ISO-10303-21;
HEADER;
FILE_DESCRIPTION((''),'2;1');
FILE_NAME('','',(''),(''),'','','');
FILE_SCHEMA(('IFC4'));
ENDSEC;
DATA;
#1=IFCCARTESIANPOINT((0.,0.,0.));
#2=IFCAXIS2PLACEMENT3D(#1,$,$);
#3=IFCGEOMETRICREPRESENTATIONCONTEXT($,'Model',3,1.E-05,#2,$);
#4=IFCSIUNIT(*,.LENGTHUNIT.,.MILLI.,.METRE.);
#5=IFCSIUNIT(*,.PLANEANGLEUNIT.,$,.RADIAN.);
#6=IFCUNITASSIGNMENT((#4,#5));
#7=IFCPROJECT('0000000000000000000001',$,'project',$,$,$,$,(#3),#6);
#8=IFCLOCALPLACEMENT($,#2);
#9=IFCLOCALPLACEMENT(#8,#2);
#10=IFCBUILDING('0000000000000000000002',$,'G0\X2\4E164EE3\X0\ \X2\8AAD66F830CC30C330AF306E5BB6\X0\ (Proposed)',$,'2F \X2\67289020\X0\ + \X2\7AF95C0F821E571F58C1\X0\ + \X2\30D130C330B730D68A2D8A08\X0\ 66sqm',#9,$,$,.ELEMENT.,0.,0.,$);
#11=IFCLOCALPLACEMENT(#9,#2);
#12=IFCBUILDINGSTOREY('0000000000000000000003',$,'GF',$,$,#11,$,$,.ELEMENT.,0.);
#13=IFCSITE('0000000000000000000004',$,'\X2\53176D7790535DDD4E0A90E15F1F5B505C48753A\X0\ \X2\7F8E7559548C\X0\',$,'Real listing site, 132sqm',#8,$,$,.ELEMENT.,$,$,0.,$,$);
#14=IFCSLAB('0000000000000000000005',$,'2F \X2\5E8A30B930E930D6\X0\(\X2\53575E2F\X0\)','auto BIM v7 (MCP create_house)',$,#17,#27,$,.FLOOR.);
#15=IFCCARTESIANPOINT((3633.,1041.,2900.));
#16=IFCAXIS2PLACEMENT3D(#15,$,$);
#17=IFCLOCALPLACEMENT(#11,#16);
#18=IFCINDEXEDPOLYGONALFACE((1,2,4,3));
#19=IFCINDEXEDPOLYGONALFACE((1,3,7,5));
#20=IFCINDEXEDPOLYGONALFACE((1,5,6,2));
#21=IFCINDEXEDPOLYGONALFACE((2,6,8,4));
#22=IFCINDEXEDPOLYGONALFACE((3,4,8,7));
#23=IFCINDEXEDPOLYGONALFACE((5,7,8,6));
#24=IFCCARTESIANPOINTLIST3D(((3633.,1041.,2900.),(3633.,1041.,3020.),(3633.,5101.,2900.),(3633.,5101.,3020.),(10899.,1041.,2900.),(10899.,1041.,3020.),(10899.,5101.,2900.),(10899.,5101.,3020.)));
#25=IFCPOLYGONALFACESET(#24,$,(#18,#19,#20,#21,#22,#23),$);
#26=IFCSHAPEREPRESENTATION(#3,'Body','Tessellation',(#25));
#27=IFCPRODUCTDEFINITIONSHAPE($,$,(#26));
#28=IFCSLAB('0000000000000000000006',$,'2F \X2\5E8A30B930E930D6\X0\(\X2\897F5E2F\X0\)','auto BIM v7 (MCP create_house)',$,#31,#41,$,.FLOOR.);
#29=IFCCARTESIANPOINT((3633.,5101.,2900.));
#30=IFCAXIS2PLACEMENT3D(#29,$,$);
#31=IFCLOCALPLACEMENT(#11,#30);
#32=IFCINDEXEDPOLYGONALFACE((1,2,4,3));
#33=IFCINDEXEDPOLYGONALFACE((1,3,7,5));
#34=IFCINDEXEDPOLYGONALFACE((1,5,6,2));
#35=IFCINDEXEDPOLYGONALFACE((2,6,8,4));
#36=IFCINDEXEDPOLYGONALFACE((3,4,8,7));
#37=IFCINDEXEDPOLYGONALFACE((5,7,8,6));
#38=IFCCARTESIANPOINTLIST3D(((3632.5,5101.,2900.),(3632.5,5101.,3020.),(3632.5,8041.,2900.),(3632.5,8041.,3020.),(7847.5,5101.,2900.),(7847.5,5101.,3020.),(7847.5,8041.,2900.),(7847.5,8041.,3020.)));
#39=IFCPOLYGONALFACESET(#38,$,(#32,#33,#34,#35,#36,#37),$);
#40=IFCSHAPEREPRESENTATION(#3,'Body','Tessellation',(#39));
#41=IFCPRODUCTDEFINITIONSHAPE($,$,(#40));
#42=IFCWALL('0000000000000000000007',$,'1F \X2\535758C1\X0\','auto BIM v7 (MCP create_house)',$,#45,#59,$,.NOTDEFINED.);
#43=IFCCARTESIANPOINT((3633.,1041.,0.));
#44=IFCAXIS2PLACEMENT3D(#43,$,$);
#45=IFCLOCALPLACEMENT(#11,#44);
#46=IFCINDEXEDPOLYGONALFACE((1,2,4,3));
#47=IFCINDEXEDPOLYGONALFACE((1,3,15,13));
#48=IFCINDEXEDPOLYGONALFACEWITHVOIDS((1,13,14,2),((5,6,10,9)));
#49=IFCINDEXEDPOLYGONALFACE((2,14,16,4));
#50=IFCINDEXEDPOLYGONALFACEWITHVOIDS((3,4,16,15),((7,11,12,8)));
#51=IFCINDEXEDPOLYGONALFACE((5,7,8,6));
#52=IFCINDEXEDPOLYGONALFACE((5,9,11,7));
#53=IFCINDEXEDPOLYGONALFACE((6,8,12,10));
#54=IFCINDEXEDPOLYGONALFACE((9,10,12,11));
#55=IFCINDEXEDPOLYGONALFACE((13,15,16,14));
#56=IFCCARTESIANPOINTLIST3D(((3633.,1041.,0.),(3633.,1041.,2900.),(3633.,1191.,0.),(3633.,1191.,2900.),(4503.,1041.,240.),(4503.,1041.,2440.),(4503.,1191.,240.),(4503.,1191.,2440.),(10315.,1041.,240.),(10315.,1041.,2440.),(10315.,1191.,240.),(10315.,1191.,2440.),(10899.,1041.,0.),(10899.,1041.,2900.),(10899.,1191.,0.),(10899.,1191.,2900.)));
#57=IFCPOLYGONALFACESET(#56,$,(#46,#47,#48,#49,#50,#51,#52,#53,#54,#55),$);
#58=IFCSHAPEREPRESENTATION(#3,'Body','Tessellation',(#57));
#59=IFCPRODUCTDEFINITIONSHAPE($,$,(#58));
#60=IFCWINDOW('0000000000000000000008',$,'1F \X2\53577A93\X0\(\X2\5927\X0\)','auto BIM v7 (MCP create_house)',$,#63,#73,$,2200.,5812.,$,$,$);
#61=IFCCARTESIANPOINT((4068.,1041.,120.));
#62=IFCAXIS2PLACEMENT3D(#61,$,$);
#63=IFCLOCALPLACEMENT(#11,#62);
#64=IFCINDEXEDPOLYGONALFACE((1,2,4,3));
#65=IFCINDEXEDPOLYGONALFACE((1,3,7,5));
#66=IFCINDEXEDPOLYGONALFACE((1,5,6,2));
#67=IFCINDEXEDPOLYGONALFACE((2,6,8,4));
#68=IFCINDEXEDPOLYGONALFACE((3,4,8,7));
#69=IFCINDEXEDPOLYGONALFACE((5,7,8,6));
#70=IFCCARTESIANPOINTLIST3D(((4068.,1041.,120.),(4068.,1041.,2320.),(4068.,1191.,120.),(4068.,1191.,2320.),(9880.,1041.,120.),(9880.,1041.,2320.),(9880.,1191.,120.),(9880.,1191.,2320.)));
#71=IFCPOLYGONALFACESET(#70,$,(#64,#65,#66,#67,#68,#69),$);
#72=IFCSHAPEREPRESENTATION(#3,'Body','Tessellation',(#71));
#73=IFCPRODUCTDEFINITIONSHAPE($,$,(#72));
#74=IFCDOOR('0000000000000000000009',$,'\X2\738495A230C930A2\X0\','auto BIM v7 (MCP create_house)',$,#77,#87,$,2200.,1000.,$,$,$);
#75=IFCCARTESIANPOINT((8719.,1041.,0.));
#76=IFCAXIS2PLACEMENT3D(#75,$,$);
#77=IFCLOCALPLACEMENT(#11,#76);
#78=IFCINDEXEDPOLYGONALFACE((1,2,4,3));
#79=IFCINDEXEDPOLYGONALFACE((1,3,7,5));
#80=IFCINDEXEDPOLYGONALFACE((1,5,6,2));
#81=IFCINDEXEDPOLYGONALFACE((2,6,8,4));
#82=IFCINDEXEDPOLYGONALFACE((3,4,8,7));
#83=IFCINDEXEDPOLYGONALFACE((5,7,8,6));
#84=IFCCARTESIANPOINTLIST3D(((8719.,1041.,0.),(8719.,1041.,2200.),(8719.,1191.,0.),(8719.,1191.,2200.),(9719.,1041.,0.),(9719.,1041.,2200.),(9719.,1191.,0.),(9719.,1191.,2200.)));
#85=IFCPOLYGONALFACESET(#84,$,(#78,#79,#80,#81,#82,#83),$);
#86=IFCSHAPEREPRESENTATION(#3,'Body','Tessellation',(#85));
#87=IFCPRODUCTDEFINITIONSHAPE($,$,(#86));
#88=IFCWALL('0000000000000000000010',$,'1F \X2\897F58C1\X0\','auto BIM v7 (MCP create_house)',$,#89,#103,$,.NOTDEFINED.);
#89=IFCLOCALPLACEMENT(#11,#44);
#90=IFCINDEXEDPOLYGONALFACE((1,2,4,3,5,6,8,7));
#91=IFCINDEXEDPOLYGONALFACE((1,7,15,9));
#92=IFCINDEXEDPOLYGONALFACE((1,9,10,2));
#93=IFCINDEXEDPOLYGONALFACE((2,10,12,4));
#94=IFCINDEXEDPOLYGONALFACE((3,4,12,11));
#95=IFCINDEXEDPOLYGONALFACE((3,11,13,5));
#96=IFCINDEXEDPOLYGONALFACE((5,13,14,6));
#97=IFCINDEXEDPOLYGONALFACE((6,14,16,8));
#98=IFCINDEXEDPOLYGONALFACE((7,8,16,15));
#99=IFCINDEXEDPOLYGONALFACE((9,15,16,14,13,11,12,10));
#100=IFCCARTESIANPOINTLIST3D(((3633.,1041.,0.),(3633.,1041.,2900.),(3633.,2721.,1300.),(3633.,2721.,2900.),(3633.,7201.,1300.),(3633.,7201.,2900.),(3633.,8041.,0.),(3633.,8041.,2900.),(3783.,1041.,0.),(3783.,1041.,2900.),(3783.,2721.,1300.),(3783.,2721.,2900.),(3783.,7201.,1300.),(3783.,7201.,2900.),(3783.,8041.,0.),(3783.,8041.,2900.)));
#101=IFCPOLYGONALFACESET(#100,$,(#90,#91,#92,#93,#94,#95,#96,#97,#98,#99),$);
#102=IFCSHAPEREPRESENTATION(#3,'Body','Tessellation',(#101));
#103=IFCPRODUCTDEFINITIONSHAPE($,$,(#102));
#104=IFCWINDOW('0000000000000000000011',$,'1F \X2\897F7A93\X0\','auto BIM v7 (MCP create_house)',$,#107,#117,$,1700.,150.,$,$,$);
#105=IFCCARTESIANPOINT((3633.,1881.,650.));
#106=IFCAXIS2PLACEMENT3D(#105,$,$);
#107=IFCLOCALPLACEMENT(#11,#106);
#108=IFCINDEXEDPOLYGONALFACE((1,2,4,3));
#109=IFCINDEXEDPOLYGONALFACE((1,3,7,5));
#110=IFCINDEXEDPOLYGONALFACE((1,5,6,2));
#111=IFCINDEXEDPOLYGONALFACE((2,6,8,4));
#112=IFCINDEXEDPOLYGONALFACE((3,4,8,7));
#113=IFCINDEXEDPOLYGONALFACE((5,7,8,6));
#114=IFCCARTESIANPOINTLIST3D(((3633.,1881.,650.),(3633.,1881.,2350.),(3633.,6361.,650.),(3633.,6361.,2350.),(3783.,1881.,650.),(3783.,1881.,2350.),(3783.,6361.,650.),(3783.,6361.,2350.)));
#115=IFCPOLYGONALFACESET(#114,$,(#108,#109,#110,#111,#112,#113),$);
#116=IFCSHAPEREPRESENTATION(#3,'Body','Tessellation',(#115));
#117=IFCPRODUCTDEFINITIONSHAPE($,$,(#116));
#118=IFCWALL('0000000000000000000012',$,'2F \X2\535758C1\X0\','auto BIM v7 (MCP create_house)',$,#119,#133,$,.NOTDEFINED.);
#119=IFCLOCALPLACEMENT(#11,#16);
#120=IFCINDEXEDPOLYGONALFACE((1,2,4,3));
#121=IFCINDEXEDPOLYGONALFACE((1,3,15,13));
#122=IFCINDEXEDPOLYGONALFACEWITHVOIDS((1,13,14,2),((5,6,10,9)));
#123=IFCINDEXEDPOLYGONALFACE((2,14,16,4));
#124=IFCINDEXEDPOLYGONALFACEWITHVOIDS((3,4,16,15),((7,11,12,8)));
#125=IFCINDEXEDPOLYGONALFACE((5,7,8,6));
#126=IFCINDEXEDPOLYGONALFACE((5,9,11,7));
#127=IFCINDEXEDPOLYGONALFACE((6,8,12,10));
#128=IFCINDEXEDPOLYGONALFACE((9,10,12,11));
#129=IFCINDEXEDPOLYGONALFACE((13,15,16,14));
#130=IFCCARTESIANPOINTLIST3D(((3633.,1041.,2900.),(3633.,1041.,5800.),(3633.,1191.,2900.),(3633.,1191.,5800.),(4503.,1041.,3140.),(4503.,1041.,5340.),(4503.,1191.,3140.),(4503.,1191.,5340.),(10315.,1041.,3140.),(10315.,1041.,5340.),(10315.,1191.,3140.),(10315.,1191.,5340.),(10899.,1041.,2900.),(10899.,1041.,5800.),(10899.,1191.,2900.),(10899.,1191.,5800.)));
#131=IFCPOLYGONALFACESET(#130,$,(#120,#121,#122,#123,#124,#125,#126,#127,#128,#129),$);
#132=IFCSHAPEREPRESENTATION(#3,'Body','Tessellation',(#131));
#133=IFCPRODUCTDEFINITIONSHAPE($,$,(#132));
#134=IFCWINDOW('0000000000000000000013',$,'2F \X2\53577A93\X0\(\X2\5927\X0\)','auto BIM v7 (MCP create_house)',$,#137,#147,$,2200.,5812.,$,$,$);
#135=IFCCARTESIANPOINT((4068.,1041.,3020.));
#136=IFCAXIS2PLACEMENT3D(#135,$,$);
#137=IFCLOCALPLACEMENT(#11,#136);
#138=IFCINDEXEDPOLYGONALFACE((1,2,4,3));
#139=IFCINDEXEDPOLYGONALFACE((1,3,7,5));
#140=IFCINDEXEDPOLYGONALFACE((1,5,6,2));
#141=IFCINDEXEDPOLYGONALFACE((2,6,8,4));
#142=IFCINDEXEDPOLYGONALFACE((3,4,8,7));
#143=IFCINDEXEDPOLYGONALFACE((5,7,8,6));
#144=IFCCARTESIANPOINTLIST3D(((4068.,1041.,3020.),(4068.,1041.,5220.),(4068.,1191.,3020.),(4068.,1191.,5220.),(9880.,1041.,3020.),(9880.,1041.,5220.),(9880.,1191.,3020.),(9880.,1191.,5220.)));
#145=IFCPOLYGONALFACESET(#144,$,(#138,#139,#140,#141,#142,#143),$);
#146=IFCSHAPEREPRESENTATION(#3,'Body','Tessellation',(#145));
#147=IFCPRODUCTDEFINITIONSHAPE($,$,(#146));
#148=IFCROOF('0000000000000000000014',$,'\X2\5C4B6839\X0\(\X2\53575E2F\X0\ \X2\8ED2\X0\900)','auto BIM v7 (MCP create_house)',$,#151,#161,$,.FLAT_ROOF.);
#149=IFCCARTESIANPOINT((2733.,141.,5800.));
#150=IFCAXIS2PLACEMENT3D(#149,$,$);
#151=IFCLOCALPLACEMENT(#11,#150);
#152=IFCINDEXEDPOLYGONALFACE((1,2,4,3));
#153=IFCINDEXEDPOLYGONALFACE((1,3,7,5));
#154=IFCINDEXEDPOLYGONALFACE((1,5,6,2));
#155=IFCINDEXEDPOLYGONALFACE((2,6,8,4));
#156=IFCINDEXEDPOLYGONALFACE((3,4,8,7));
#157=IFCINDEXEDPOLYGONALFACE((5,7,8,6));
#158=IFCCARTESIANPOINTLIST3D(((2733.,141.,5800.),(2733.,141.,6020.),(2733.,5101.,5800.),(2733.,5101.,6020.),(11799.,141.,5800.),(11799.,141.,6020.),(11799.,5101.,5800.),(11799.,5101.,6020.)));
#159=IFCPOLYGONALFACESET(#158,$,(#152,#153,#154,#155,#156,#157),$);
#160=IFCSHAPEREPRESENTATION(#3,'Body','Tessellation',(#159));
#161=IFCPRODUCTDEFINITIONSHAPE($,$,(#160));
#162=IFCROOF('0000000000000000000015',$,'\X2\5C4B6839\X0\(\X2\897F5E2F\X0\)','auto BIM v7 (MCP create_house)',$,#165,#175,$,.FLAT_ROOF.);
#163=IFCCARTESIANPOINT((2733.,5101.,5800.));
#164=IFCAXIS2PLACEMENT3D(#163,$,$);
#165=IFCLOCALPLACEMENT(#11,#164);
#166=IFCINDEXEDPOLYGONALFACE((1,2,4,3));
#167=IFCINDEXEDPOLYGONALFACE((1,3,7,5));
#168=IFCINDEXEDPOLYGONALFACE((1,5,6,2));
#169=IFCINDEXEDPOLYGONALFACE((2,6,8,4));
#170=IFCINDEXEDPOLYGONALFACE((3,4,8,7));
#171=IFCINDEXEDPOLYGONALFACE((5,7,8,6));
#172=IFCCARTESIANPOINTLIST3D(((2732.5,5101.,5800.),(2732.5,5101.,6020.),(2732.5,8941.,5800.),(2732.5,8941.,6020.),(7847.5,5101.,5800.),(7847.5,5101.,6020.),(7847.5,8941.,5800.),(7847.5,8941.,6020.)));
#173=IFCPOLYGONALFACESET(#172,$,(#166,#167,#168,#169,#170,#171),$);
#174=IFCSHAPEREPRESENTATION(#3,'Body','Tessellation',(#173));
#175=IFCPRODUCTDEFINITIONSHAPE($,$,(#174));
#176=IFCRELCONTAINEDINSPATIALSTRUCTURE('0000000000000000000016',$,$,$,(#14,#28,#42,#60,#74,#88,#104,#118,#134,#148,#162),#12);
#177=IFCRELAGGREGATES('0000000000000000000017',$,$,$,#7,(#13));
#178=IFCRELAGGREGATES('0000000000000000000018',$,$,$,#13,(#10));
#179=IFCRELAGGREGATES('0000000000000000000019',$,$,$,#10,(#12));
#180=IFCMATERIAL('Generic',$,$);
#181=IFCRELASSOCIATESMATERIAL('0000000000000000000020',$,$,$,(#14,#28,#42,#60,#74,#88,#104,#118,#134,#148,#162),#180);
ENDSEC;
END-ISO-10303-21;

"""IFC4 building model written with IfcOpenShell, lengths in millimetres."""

from ifc_helpers import new_model, si_unit, frame, frame_2d, origin, place, context, project, spatial, rectangle, extrude, material, element, fill, save


model = new_model("IFC4")

# Units and contexts
model_context = context("Model", 3, precision=1e-05, world=origin())
ifc_project = project(units=[si_unit("LENGTHUNIT", "METRE", prefix="MILLI"), si_unit("PLANEANGLEUNIT", "RADIAN")], contexts=[model_context])

# Site, building, storey
site_placement = place(None, origin())
site = spatial("IfcSite", under=ifc_project, at=site_placement, Name="北海道川上郡弟子屈町 美留和", ObjectType="Real listing site, 132sqm", CompositionType="ELEMENT", RefElevation=0.0)
building_placement = place(site_placement, origin())
building = spatial("IfcBuilding", under=site, at=building_placement, Name="G0世代 読書ヌックの家 (Proposed)", ObjectType="2F 木造 + 竹小舞土壁 + パッシブ設計 66sqm", CompositionType="ELEMENT", ElevationOfRefHeight=0.0, ElevationOfTerrain=0.0)
storey_placement = place(building_placement, origin())
storey = spatial("IfcBuildingStorey", under=building, at=storey_placement, Name="GF", CompositionType="ELEMENT", Elevation=0.0)

# Slabs
ifc_material = material(Name="Generic")
slab_1_placement = place(storey_placement, frame((3633.0, 1041.0, 2900.0)))
element("IfcSlab", 1, at=slab_1_placement, inside=storey, material=ifc_material, Name="2F 床スラブ(南帯)", Description="auto BIM v7 (MCP create_house)", PredefinedType="FLOOR", context=model_context, shape_type="SweptSolid", body=[
    extrude(rectangle(XDim=7266.0, YDim=4060.0, at=frame_2d((3633.0, 2030.0))), frame((3633.0, 1041.0, 2900.0)), (0.0, 0.0, 1.0), 120.0),
])
slab_2_placement = place(storey_placement, frame((3633.0, 5101.0, 2900.0)))
element("IfcSlab", 2, at=slab_2_placement, inside=storey, material=ifc_material, Name="2F 床スラブ(西帯)", Description="auto BIM v7 (MCP create_house)", PredefinedType="FLOOR", context=model_context, shape_type="SweptSolid", body=[
    extrude(rectangle(XDim=4215.0, YDim=2940.0, at=frame_2d((2107.0, 1470.0))), frame((3633.0, 5101.0, 2900.0)), (0.0, 0.0, 1.0), 120.0),
])

# Wall, openings, window, door
wall_1_placement = place(storey_placement, frame((3633.0, 1041.0, 0.0)))
wall_1 = element("IfcWall", 3, at=wall_1_placement, inside=storey, material=ifc_material, Name="1F 南壁", Description="auto BIM v7 (MCP create_house)", PredefinedType="NOTDEFINED", context=model_context, shape_type="SweptSolid", body=[
    extrude(rectangle(XDim=7266.0, YDim=150.0, at=frame_2d((3633.0, 75.0))), frame((3633.0, 1041.0, 0.0)), (0.0, 0.0, 1.0), 2900.0),
])
opening_1_placement = place(storey_placement, frame((4068.0, 1041.0, 120.0)))
opening_1 = element("IfcOpeningElement", 4, at=opening_1_placement, cuts=wall_1, PredefinedType="NOTDEFINED", context=model_context, shape_type="SweptSolid", body=[
    extrude(rectangle(XDim=5812.0, YDim=150.0, at=frame_2d((2906.0, 75.0))), frame((4068.0, 1041.0, 120.0)), (0.0, 0.0, 1.0), 2200.0),
])
opening_2_placement = place(storey_placement, frame((8719.0, 1041.0, 0.0)))
opening_2 = element("IfcOpeningElement", 5, at=opening_2_placement, cuts=wall_1, PredefinedType="NOTDEFINED", context=model_context, shape_type="SweptSolid", body=[
    extrude(rectangle(XDim=1000.0, YDim=150.0, at=frame_2d((500.0, 75.0))), frame((8719.0, 1041.0, 0.0)), (0.0, 0.0, 1.0), 2200.0),
])
window_1_placement = place(storey_placement, frame((4068.0, 1041.0, 120.0)))
window_1 = element("IfcWindow", 6, at=window_1_placement, inside=storey, material=ifc_material, Name="1F 南窓(大)", Description="auto BIM v7 (MCP create_house)", OverallHeight=2200.0, OverallWidth=5812.0, context=model_context, shape_type="SweptSolid", body=[
    extrude(rectangle(XDim=5812.0, YDim=150.0, at=frame_2d((2906.0, 75.0))), frame((4068.0, 1041.0, 120.0)), (0.0, 0.0, 1.0), 2200.0),
])
fill(opening_1, window_1)
door_placement = place(storey_placement, frame((8719.0, 1041.0, 0.0)))
door = element("IfcDoor", 7, at=door_placement, inside=storey, material=ifc_material, Name="玄関ドア", Description="auto BIM v7 (MCP create_house)", OverallHeight=2200.0, OverallWidth=1000.0, context=model_context, shape_type="SweptSolid", body=[
    extrude(rectangle(XDim=1000.0, YDim=150.0, at=frame_2d((500.0, 75.0))), frame((8719.0, 1041.0, 0.0)), (0.0, 0.0, 1.0), 2200.0),
])
fill(opening_2, door)

# Wall, opening, window
wall_2_placement = place(storey_placement, frame((3633.0, 1041.0, 0.0)))
wall_2 = element("IfcWall", 8, at=wall_2_placement, inside=storey, material=ifc_material, Name="1F 西壁", Description="auto BIM v7 (MCP create_house)", PredefinedType="NOTDEFINED", context=model_context, shape_type="SweptSolid", body=[
    extrude(rectangle(XDim=150.0, YDim=7000.0, at=frame_2d((75.0, 3500.0))), frame((3633.0, 1041.0, 0.0)), (0.0, 0.0, 1.0), 2900.0),
])
opening_3_placement = place(storey_placement, frame((3633.0, 1881.0, 650.0)))
opening_3 = element("IfcOpeningElement", 9, at=opening_3_placement, cuts=wall_2, PredefinedType="NOTDEFINED", context=model_context, shape_type="SweptSolid", body=[
    extrude(rectangle(XDim=150.0, YDim=4480.0, at=frame_2d((75.0, 2240.0))), frame((3633.0, 1881.0, 650.0)), (0.0, 0.0, 1.0), 1700.0),
])
window_2_placement = place(storey_placement, frame((3633.0, 1881.0, 650.0)))
window_2 = element("IfcWindow", 10, at=window_2_placement, inside=storey, material=ifc_material, Name="1F 西窓", Description="auto BIM v7 (MCP create_house)", OverallHeight=1700.0, OverallWidth=150.0, context=model_context, shape_type="SweptSolid", body=[
    extrude(rectangle(XDim=150.0, YDim=4480.0, at=frame_2d((75.0, 2240.0))), frame((3633.0, 1881.0, 650.0)), (0.0, 0.0, 1.0), 1700.0),
])
fill(opening_3, window_2)

# Wall, opening, window
wall_3_placement = place(storey_placement, frame((3633.0, 1041.0, 2900.0)))
wall_3 = element("IfcWall", 11, at=wall_3_placement, inside=storey, material=ifc_material, Name="2F 南壁", Description="auto BIM v7 (MCP create_house)", PredefinedType="NOTDEFINED", context=model_context, shape_type="SweptSolid", body=[
    extrude(rectangle(XDim=7266.0, YDim=150.0, at=frame_2d((3633.0, 75.0))), frame((3633.0, 1041.0, 2900.0)), (0.0, 0.0, 1.0), 2900.0),
])
opening_4_placement = place(storey_placement, frame((4068.0, 1041.0, 3020.0)))
opening_4 = element("IfcOpeningElement", 12, at=opening_4_placement, cuts=wall_3, PredefinedType="NOTDEFINED", context=model_context, shape_type="SweptSolid", body=[
    extrude(rectangle(XDim=5812.0, YDim=150.0, at=frame_2d((2906.0, 75.0))), frame((4068.0, 1041.0, 3020.0)), (0.0, 0.0, 1.0), 2200.0),
])
window_3_placement = place(storey_placement, frame((4068.0, 1041.0, 3020.0)))
window_3 = element("IfcWindow", 13, at=window_3_placement, inside=storey, material=ifc_material, Name="2F 南窓(大)", Description="auto BIM v7 (MCP create_house)", OverallHeight=2200.0, OverallWidth=5812.0, context=model_context, shape_type="SweptSolid", body=[
    extrude(rectangle(XDim=5812.0, YDim=150.0, at=frame_2d((2906.0, 75.0))), frame((4068.0, 1041.0, 3020.0)), (0.0, 0.0, 1.0), 2200.0),
])
fill(opening_4, window_3)

# Roofs
roof_1_placement = place(storey_placement, frame((2733.0, 141.0, 5800.0)))
element("IfcRoof", 14, at=roof_1_placement, inside=storey, material=ifc_material, Name="屋根(南帯 軒900)", Description="auto BIM v7 (MCP create_house)", PredefinedType="FLAT_ROOF", context=model_context, shape_type="SweptSolid", body=[
    extrude(rectangle(XDim=9066.0, YDim=4960.0, at=frame_2d((4533.0, 2480.0))), frame((2733.0, 141.0, 5800.0)), (0.0, 0.0, 1.0), 220.0),
])
roof_2_placement = place(storey_placement, frame((2733.0, 5101.0, 5800.0)))
element("IfcRoof", 15, at=roof_2_placement, inside=storey, material=ifc_material, Name="屋根(西帯)", Description="auto BIM v7 (MCP create_house)", PredefinedType="FLAT_ROOF", context=model_context, shape_type="SweptSolid", body=[
    extrude(rectangle(XDim=5115.0, YDim=3840.0, at=frame_2d((2557.0, 1920.0))), frame((2733.0, 5101.0, 5800.0)), (0.0, 0.0, 1.0), 220.0),
])

save(model, "model.ifc")
